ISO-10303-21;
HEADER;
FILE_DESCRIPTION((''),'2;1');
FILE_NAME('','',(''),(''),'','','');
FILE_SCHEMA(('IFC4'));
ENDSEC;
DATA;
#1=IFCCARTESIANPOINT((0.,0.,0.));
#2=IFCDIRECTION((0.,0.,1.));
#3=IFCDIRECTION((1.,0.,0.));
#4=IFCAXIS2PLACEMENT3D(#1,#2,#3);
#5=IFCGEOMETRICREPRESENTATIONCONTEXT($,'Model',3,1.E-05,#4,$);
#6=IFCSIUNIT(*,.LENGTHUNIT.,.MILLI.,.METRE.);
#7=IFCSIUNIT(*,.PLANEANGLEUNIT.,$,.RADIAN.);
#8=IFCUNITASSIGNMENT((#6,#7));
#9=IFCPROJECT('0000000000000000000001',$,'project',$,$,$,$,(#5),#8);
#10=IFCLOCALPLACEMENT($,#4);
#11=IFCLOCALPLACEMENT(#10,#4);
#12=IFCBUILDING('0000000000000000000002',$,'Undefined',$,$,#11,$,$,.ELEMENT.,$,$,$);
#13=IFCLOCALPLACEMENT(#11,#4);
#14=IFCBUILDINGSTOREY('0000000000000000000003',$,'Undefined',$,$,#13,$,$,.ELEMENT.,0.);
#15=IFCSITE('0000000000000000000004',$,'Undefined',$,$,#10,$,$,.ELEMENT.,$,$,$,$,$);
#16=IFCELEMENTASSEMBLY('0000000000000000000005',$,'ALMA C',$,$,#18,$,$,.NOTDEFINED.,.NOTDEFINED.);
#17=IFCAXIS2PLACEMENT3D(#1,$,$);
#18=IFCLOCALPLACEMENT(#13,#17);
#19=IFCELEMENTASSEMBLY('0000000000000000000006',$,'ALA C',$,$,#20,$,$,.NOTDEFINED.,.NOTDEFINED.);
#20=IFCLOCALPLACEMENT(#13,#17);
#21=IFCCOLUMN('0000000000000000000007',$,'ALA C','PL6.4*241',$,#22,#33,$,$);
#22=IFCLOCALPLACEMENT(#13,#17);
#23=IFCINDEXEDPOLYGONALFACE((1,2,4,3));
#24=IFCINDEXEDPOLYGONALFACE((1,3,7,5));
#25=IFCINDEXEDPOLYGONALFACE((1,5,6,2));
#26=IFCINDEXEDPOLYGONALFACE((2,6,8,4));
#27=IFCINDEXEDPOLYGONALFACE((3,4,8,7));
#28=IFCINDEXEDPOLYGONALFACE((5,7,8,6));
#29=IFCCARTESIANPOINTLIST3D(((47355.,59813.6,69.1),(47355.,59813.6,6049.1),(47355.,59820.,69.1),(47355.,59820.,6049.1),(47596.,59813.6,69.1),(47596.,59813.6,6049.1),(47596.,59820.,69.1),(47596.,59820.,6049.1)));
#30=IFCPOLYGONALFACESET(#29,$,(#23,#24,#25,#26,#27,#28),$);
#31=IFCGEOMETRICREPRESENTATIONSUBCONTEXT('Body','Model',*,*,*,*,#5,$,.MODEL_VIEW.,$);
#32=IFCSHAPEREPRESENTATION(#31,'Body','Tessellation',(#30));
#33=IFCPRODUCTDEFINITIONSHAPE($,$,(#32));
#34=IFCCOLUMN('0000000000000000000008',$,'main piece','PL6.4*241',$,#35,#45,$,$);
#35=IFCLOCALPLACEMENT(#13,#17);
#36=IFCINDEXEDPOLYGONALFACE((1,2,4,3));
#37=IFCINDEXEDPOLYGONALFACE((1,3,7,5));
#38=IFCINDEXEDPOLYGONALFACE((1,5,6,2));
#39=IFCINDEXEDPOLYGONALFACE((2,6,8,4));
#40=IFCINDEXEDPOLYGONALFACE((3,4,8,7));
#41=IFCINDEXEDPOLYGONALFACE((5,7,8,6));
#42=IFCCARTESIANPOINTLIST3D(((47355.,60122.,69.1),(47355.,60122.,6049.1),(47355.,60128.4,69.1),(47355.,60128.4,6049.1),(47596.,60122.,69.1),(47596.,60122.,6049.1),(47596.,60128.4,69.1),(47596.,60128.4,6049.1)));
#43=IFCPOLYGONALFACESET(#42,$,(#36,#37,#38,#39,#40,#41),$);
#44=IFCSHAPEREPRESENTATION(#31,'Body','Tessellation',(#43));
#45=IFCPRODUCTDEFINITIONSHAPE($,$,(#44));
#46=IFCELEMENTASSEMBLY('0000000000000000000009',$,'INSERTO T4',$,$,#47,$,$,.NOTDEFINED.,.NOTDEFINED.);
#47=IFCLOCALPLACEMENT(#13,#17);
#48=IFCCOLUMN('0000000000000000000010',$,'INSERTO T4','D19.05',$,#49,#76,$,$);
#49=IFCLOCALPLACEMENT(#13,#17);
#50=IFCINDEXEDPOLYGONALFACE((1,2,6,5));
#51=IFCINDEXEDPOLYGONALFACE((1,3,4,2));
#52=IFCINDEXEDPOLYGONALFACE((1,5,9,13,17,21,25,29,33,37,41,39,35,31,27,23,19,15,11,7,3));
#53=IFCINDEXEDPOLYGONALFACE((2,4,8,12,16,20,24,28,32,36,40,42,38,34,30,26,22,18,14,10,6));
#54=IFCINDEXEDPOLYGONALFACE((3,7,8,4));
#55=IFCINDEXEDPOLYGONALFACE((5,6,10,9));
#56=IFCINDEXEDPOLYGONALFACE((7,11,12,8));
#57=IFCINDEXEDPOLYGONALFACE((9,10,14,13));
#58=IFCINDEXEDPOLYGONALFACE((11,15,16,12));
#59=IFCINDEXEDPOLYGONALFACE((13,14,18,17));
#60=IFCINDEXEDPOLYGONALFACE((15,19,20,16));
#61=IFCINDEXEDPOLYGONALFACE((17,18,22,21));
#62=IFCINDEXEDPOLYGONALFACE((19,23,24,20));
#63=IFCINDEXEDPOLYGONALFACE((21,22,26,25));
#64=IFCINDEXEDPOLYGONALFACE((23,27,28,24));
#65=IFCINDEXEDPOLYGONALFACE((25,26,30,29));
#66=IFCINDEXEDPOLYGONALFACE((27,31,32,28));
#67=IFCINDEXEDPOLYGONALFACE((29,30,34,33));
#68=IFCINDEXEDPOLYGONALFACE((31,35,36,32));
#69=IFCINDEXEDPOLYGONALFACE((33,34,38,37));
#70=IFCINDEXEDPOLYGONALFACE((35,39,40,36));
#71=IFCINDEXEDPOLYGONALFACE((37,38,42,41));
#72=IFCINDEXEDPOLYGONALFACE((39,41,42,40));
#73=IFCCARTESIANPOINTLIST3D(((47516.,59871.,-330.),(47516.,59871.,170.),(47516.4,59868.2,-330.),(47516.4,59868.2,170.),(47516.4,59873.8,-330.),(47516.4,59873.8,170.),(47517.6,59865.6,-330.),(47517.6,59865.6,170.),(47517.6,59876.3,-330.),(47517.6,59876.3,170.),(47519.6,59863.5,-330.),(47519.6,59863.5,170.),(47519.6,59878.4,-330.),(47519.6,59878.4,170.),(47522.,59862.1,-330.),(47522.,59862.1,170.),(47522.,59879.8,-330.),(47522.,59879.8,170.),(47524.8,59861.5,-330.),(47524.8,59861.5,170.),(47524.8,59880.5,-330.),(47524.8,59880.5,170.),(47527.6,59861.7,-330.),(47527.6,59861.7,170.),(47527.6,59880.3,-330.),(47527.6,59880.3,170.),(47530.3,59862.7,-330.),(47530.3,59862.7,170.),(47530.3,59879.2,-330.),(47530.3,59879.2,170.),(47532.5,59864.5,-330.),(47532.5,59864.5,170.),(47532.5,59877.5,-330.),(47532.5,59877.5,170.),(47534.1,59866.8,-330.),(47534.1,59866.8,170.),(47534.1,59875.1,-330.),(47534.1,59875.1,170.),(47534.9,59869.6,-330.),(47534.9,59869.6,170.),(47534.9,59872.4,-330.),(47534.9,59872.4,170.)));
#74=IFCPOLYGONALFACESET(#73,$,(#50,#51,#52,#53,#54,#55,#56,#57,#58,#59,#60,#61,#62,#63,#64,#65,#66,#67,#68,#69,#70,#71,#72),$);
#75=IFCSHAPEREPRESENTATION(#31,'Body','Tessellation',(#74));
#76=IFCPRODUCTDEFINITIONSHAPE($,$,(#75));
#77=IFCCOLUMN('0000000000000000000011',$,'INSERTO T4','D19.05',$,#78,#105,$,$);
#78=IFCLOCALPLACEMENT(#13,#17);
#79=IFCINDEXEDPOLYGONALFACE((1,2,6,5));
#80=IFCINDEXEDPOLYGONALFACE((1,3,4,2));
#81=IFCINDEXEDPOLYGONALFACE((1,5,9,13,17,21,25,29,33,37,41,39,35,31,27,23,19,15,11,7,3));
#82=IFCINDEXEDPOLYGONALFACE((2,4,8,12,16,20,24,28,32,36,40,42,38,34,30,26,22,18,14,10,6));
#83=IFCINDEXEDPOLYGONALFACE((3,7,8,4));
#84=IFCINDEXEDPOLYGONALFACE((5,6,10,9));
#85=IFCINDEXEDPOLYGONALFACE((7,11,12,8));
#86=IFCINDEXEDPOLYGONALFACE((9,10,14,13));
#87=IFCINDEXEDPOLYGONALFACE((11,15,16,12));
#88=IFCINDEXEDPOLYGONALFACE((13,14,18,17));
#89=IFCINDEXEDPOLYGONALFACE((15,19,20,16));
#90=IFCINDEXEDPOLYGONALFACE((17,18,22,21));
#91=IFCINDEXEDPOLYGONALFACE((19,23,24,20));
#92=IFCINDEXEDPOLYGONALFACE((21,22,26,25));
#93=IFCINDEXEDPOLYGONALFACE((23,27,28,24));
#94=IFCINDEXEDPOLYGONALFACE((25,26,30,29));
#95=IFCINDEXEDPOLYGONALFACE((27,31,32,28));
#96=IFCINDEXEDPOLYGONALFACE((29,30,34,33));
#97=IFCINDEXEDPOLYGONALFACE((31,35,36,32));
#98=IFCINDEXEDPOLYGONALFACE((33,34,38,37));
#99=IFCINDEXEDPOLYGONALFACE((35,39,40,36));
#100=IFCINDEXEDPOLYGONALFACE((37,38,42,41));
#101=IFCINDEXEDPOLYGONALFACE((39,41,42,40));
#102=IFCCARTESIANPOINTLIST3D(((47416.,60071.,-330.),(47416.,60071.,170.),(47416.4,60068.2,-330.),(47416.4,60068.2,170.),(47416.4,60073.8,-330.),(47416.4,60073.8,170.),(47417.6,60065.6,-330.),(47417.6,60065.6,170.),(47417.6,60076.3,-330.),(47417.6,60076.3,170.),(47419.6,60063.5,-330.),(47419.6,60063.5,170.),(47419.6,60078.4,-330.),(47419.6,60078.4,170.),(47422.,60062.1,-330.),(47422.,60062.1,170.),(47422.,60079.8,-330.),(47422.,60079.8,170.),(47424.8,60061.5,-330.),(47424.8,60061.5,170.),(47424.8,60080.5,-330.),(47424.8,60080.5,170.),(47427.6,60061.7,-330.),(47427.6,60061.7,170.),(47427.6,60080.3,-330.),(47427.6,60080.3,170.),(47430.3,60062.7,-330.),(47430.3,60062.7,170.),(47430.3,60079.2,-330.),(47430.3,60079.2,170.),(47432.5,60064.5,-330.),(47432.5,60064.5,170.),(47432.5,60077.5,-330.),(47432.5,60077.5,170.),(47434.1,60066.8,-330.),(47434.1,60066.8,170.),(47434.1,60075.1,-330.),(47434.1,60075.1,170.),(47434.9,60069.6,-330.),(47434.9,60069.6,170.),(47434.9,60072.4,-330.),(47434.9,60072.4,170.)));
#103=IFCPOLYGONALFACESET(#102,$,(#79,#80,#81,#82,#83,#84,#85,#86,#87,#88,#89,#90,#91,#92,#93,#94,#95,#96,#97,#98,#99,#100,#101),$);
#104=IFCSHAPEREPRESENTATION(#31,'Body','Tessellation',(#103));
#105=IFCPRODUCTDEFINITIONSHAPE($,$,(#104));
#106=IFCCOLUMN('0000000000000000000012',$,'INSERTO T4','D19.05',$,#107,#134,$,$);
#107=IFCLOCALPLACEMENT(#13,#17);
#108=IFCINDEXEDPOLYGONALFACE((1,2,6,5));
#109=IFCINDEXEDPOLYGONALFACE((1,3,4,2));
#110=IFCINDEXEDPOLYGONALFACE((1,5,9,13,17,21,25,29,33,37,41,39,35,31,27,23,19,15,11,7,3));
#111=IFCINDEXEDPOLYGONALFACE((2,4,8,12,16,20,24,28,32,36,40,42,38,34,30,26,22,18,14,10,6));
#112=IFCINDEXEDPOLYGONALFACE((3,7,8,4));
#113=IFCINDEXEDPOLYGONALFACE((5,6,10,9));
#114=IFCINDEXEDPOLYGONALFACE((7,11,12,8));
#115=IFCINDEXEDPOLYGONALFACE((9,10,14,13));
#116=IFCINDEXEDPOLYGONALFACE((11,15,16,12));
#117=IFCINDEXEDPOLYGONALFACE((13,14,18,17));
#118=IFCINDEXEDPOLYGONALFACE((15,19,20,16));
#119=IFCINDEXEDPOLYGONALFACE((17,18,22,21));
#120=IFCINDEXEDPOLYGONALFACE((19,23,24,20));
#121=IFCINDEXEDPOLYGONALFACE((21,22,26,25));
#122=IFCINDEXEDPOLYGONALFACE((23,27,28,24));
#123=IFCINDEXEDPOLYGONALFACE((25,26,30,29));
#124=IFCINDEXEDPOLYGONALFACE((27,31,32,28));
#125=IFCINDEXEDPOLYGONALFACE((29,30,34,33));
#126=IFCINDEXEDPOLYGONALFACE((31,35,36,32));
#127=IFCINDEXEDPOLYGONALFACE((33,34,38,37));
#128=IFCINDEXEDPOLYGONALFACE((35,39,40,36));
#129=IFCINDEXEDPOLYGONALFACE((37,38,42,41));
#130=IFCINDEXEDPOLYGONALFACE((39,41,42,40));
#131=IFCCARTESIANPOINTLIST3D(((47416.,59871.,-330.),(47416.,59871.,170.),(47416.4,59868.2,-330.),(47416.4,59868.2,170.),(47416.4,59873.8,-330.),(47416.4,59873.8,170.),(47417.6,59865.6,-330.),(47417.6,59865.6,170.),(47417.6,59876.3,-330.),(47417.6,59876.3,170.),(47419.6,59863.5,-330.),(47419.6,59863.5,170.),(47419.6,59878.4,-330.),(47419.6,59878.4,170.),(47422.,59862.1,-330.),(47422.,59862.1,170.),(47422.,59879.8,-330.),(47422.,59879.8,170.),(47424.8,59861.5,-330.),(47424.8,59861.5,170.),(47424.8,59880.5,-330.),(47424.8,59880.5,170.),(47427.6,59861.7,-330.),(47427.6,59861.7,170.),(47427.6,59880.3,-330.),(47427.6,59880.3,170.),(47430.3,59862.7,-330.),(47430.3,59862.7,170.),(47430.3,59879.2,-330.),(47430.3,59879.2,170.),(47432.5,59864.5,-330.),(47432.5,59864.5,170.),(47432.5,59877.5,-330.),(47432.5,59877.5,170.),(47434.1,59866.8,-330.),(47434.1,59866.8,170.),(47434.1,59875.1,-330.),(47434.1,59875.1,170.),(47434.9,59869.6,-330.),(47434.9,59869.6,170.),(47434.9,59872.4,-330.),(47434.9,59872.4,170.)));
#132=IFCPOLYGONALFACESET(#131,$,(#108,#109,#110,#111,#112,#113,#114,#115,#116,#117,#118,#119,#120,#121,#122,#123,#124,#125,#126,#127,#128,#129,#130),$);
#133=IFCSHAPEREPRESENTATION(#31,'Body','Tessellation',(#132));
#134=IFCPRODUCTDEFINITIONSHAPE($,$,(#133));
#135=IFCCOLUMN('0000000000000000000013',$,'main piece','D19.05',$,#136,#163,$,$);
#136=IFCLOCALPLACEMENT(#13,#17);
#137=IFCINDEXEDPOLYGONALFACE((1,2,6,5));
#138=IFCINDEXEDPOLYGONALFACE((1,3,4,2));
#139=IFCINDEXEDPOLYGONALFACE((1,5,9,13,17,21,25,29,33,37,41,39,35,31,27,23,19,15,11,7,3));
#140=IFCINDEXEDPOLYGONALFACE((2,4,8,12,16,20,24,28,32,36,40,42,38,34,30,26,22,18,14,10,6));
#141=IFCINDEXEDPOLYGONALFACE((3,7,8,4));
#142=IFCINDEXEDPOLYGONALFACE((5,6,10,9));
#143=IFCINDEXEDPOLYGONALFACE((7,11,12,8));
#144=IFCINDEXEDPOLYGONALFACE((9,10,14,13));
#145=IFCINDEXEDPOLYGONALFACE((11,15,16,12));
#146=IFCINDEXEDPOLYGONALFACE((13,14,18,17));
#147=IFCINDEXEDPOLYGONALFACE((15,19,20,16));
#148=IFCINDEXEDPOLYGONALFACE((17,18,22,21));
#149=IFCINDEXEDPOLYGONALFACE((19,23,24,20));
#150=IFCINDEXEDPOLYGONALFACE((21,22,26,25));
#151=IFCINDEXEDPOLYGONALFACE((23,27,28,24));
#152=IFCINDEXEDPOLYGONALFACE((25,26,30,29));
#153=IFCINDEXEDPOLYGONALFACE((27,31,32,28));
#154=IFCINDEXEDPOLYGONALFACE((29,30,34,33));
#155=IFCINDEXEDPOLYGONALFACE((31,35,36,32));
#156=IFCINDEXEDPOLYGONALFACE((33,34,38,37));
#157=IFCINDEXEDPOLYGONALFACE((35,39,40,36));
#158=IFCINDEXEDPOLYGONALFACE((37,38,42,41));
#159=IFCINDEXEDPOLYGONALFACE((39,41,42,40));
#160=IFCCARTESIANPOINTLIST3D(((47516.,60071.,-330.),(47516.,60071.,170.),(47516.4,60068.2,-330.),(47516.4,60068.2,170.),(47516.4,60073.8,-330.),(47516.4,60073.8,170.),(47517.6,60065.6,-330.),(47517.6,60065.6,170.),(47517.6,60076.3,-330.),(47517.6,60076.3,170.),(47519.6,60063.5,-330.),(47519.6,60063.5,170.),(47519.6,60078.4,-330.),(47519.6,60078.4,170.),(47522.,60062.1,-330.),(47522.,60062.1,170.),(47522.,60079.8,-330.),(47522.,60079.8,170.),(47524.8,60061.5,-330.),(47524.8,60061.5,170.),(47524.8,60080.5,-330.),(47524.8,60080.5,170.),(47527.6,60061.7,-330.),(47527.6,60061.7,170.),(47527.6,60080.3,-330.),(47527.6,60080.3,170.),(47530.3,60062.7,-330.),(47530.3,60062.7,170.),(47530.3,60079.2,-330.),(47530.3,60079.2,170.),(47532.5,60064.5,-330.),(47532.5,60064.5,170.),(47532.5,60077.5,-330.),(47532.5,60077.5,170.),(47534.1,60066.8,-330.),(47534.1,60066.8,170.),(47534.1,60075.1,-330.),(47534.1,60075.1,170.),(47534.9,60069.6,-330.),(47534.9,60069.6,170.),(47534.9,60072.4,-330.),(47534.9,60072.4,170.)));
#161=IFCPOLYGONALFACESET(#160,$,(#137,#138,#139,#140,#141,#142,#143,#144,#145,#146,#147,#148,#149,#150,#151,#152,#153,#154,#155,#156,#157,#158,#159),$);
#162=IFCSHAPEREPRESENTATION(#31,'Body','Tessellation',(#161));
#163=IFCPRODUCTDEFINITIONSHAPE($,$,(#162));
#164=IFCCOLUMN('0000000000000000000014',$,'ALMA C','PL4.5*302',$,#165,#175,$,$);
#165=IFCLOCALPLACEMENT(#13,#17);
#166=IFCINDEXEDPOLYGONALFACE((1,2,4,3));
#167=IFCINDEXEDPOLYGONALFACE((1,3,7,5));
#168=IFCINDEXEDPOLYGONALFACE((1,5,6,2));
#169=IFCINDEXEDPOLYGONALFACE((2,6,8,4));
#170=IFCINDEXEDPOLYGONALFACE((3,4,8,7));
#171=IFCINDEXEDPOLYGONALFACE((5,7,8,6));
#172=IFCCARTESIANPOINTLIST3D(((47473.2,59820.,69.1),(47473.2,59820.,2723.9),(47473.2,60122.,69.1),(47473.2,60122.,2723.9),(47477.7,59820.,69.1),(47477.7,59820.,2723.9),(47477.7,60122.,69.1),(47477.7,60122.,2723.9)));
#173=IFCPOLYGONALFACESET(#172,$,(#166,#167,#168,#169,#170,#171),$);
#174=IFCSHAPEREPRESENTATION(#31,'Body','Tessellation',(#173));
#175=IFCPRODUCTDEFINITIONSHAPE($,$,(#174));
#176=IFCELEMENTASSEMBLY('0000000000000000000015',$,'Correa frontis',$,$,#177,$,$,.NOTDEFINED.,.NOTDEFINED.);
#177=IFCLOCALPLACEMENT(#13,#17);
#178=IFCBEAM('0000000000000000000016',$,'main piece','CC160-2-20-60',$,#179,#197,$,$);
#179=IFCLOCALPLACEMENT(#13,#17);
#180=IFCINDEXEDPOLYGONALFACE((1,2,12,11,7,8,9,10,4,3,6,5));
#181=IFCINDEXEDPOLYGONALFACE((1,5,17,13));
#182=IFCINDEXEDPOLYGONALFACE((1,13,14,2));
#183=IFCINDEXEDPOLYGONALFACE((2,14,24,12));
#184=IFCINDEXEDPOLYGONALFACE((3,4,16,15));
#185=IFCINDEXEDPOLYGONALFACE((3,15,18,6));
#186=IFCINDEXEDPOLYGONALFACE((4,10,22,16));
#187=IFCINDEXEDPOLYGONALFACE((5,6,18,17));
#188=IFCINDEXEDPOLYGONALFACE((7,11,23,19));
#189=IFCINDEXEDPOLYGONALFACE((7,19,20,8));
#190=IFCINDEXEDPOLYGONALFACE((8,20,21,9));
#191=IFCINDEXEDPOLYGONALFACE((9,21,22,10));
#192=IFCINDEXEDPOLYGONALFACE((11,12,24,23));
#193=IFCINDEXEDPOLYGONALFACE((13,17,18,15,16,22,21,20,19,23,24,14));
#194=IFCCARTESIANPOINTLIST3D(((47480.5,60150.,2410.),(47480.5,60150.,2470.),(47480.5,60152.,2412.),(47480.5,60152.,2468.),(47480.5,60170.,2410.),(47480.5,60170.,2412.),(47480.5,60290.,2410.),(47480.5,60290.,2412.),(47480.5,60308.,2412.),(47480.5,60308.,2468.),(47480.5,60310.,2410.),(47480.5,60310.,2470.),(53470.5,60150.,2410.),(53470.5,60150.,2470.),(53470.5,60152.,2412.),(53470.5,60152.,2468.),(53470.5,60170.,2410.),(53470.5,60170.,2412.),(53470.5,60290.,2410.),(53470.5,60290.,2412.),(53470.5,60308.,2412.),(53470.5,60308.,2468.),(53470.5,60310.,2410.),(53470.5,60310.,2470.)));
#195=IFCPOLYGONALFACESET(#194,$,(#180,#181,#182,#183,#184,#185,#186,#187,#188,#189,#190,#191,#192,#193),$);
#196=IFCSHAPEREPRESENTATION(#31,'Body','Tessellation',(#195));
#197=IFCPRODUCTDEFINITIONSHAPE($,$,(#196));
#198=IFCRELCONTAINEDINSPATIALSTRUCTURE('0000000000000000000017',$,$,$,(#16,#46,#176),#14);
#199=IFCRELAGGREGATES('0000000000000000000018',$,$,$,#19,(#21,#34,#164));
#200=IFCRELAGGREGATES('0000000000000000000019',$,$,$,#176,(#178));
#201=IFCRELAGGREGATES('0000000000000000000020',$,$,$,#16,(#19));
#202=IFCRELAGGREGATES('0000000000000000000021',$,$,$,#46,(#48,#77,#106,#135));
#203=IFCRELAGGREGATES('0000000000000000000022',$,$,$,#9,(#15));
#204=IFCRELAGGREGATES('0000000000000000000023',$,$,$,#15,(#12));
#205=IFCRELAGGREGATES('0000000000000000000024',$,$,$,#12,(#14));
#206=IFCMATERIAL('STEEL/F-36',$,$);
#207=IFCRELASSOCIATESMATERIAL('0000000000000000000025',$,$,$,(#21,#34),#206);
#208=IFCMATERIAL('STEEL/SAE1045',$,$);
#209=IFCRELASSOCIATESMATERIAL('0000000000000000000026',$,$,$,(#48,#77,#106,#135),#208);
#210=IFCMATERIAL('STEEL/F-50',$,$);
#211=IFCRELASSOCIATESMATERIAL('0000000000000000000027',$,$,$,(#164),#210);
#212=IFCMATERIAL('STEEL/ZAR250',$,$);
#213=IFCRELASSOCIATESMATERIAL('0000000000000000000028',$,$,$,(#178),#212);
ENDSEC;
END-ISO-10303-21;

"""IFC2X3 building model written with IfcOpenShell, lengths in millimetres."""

from ifc_helpers import new_model, si_unit, frame, origin_with_axes, origin_2d_with_axis, place, context, subcontext, project, spatial, rectangle, circle, c_section, extrude, material, element, aggregate, save


model = new_model("IFC2X3")

# Units and contexts
model_context = context("Model", 3, precision=1e-05, world=origin_with_axes())
body_context = subcontext(model_context, "Body", "Model", "MODEL_VIEW")
ifc_project = project(units=[si_unit("LENGTHUNIT", "METRE", prefix="MILLI"), si_unit("PLANEANGLEUNIT", "RADIAN")], contexts=[model_context])

# Site, building, storey
site_placement = place(None, origin_with_axes())
site = spatial("IfcSite", under=ifc_project, at=site_placement, Name="Undefined", CompositionType="ELEMENT")
building_placement = place(site_placement, origin_with_axes())
building = spatial("IfcBuilding", under=site, at=building_placement, Name="Undefined", CompositionType="ELEMENT")
storey_placement = place(building_placement, origin_with_axes())
storey = spatial("IfcBuildingStorey", under=building, at=storey_placement, Name="Undefined", CompositionType="ELEMENT", Elevation=0.0)

# Element assemblies, columns
assembly_1_placement = place(storey_placement, origin_with_axes())
assembly_1 = element("IfcElementAssembly", 1, at=assembly_1_placement, inside=storey, Name="ALMA C", AssemblyPlace="NOTDEFINED", PredefinedType="NOTDEFINED")
assembly_2_placement = place(assembly_1_placement, origin_with_axes())
assembly_2 = element("IfcElementAssembly", 2, at=assembly_2_placement, Name="ALA C", AssemblyPlace="NOTDEFINED", PredefinedType="NOTDEFINED")
ifc_material_1 = material(Name="STEEL/F-36")
column_1_placement = place(assembly_2_placement, frame((47475.5, 59816.8, 69.1), z_axis=(0.0, 0.0, 1.0), x_axis=(-1.0, 0.0, 0.0)))
column_1 = element("IfcColumn", 3, at=column_1_placement, material=ifc_material_1, Name="ALA C", Description="PL6.4*241", context=body_context, shape_type="SweptSolid", body=[
    extrude(rectangle(XDim=6.4, YDim=241.0, at=origin_2d_with_axis()), frame((0.0, 0.0, 5980.0), z_axis=(0.0, 0.0, -1.0), x_axis=(0.0, 1.0, 0.0)), (0.0, 0.0, 1.0), 5980.0),
])
column_2_placement = place(assembly_2_placement, frame((47475.5, 60125.2, 69.1), z_axis=(0.0, 0.0, 1.0), x_axis=(-1.0, 0.0, 0.0)))
column_2 = element("IfcColumn", 4, at=column_2_placement, material=ifc_material_1, Name="main piece", Description="PL6.4*241", context=body_context, shape_type="SweptSolid", body=[
    extrude(rectangle(XDim=6.4, YDim=241.0, at=origin_2d_with_axis()), frame((0.0, 0.0, 5980.0), z_axis=(0.0, 0.0, -1.0), x_axis=(0.0, 1.0, 0.0)), (0.0, 0.0, 1.0), 5980.0),
])

# Element assembly, columns
assembly_3_placement = place(storey_placement, origin_with_axes())
assembly_3 = element("IfcElementAssembly", 5, at=assembly_3_placement, inside=storey, Name="INSERTO T4", AssemblyPlace="NOTDEFINED", PredefinedType="NOTDEFINED")
ifc_material_2 = material(Name="STEEL/SAE1045")
column_3_placement = place(assembly_3_placement, frame((47525.5, 59871.0, -330.0), z_axis=(0.0, 0.0, 1.0), x_axis=(0.0, 1.0, 0.0)))
column_3 = element("IfcColumn", 6, at=column_3_placement, material=ifc_material_2, Name="INSERTO T4", Description="D19.05", context=body_context, shape_type="SweptSolid", body=[
    extrude(circle(Radius=9.5, at=origin_2d_with_axis()), frame((0.0, 0.0, 500.0), z_axis=(0.0, 0.0, -1.0), x_axis=(0.0, 1.0, 0.0)), (0.0, 0.0, 1.0), 500.0),
])
column_4_placement = place(assembly_3_placement, frame((47425.5, 60071.0, -330.0), z_axis=(0.0, 0.0, 1.0), x_axis=(0.0, 1.0, 0.0)))
column_4 = element("IfcColumn", 7, at=column_4_placement, material=ifc_material_2, Name="INSERTO T4", Description="D19.05", context=body_context, shape_type="SweptSolid", body=[
    extrude(circle(Radius=9.5, at=origin_2d_with_axis()), frame((0.0, 0.0, 500.0), z_axis=(0.0, 0.0, -1.0), x_axis=(0.0, 1.0, 0.0)), (0.0, 0.0, 1.0), 500.0),
])
column_5_placement = place(assembly_3_placement, frame((47425.5, 59871.0, -330.0), z_axis=(0.0, 0.0, 1.0), x_axis=(0.0, 1.0, 0.0)))
column_5 = element("IfcColumn", 8, at=column_5_placement, material=ifc_material_2, Name="INSERTO T4", Description="D19.05", context=body_context, shape_type="SweptSolid", body=[
    extrude(circle(Radius=9.5, at=origin_2d_with_axis()), frame((0.0, 0.0, 500.0), z_axis=(0.0, 0.0, -1.0), x_axis=(0.0, 1.0, 0.0)), (0.0, 0.0, 1.0), 500.0),
])
column_6_placement = place(assembly_3_placement, frame((47525.5, 60071.0, -330.0), z_axis=(0.0, 0.0, 1.0), x_axis=(0.0, 1.0, 0.0)))
column_6 = element("IfcColumn", 9, at=column_6_placement, material=ifc_material_2, Name="main piece", Description="D19.05", context=body_context, shape_type="SweptSolid", body=[
    extrude(circle(Radius=9.5, at=origin_2d_with_axis()), frame((0.0, 0.0, 500.0), z_axis=(0.0, 0.0, -1.0), x_axis=(0.0, 1.0, 0.0)), (0.0, 0.0, 1.0), 500.0),
])

# Column
ifc_material_3 = material(Name="STEEL/F-50")
column_7_placement = place(assembly_2_placement, frame((47475.5, 59971.0, 69.1), z_axis=(-0.000002, 0.0, 1.0), x_axis=(0.0, 1.0, 0.0)))
column_7 = element("IfcColumn", 10, at=column_7_placement, material=ifc_material_3, Name="ALMA C", Description="PL4.5*302", context=body_context, shape_type="SweptSolid", body=[
    extrude(rectangle(XDim=4.5, YDim=302.0, at=origin_2d_with_axis()), frame((0.0, 0.0, 2654.8), z_axis=(0.0, 0.0, -1.0), x_axis=(0.0, 1.0, 0.0)), (0.0, 0.0, 1.0), 2654.8),
])
aggregate(assembly_2, [column_1, column_2, column_7])

# Element assembly, beam
assembly_4_placement = place(storey_placement, origin_with_axes())
assembly_4 = element("IfcElementAssembly", 11, at=assembly_4_placement, inside=storey, Name="Correa frontis", AssemblyPlace="NOTDEFINED", PredefinedType="NOTDEFINED")
ifc_material_4 = material(Name="STEEL/ZAR250")
beam_1_placement = place(assembly_4_placement, frame((47480.5, 60230.0, 2440.0), z_axis=(0.0, -1.0, 0.0), x_axis=(1.0, 0.0, 0.0)))
beam_1 = element("IfcBeam", 12, at=beam_1_placement, material=ifc_material_4, Name="main piece", Description="CC160-2-20-60", context=body_context, shape_type="SweptSolid", body=[
    extrude(c_section(Depth=160.0, Width=60.0, WallThickness=2.0, Girth=20.0, at=origin_2d_with_axis()), frame((5990.0, 0.0, 0.0), z_axis=(-1.0, 0.0, 0.0), x_axis=(0.0, -1.0, 0.0)), (0.0, 0.0, 1.0), 5990.0),
])
aggregate(assembly_4, [beam_1])

aggregate(assembly_1, [assembly_2])

aggregate(assembly_3, [column_3, column_4, column_5, column_6])

save(model, "model.ifc")
